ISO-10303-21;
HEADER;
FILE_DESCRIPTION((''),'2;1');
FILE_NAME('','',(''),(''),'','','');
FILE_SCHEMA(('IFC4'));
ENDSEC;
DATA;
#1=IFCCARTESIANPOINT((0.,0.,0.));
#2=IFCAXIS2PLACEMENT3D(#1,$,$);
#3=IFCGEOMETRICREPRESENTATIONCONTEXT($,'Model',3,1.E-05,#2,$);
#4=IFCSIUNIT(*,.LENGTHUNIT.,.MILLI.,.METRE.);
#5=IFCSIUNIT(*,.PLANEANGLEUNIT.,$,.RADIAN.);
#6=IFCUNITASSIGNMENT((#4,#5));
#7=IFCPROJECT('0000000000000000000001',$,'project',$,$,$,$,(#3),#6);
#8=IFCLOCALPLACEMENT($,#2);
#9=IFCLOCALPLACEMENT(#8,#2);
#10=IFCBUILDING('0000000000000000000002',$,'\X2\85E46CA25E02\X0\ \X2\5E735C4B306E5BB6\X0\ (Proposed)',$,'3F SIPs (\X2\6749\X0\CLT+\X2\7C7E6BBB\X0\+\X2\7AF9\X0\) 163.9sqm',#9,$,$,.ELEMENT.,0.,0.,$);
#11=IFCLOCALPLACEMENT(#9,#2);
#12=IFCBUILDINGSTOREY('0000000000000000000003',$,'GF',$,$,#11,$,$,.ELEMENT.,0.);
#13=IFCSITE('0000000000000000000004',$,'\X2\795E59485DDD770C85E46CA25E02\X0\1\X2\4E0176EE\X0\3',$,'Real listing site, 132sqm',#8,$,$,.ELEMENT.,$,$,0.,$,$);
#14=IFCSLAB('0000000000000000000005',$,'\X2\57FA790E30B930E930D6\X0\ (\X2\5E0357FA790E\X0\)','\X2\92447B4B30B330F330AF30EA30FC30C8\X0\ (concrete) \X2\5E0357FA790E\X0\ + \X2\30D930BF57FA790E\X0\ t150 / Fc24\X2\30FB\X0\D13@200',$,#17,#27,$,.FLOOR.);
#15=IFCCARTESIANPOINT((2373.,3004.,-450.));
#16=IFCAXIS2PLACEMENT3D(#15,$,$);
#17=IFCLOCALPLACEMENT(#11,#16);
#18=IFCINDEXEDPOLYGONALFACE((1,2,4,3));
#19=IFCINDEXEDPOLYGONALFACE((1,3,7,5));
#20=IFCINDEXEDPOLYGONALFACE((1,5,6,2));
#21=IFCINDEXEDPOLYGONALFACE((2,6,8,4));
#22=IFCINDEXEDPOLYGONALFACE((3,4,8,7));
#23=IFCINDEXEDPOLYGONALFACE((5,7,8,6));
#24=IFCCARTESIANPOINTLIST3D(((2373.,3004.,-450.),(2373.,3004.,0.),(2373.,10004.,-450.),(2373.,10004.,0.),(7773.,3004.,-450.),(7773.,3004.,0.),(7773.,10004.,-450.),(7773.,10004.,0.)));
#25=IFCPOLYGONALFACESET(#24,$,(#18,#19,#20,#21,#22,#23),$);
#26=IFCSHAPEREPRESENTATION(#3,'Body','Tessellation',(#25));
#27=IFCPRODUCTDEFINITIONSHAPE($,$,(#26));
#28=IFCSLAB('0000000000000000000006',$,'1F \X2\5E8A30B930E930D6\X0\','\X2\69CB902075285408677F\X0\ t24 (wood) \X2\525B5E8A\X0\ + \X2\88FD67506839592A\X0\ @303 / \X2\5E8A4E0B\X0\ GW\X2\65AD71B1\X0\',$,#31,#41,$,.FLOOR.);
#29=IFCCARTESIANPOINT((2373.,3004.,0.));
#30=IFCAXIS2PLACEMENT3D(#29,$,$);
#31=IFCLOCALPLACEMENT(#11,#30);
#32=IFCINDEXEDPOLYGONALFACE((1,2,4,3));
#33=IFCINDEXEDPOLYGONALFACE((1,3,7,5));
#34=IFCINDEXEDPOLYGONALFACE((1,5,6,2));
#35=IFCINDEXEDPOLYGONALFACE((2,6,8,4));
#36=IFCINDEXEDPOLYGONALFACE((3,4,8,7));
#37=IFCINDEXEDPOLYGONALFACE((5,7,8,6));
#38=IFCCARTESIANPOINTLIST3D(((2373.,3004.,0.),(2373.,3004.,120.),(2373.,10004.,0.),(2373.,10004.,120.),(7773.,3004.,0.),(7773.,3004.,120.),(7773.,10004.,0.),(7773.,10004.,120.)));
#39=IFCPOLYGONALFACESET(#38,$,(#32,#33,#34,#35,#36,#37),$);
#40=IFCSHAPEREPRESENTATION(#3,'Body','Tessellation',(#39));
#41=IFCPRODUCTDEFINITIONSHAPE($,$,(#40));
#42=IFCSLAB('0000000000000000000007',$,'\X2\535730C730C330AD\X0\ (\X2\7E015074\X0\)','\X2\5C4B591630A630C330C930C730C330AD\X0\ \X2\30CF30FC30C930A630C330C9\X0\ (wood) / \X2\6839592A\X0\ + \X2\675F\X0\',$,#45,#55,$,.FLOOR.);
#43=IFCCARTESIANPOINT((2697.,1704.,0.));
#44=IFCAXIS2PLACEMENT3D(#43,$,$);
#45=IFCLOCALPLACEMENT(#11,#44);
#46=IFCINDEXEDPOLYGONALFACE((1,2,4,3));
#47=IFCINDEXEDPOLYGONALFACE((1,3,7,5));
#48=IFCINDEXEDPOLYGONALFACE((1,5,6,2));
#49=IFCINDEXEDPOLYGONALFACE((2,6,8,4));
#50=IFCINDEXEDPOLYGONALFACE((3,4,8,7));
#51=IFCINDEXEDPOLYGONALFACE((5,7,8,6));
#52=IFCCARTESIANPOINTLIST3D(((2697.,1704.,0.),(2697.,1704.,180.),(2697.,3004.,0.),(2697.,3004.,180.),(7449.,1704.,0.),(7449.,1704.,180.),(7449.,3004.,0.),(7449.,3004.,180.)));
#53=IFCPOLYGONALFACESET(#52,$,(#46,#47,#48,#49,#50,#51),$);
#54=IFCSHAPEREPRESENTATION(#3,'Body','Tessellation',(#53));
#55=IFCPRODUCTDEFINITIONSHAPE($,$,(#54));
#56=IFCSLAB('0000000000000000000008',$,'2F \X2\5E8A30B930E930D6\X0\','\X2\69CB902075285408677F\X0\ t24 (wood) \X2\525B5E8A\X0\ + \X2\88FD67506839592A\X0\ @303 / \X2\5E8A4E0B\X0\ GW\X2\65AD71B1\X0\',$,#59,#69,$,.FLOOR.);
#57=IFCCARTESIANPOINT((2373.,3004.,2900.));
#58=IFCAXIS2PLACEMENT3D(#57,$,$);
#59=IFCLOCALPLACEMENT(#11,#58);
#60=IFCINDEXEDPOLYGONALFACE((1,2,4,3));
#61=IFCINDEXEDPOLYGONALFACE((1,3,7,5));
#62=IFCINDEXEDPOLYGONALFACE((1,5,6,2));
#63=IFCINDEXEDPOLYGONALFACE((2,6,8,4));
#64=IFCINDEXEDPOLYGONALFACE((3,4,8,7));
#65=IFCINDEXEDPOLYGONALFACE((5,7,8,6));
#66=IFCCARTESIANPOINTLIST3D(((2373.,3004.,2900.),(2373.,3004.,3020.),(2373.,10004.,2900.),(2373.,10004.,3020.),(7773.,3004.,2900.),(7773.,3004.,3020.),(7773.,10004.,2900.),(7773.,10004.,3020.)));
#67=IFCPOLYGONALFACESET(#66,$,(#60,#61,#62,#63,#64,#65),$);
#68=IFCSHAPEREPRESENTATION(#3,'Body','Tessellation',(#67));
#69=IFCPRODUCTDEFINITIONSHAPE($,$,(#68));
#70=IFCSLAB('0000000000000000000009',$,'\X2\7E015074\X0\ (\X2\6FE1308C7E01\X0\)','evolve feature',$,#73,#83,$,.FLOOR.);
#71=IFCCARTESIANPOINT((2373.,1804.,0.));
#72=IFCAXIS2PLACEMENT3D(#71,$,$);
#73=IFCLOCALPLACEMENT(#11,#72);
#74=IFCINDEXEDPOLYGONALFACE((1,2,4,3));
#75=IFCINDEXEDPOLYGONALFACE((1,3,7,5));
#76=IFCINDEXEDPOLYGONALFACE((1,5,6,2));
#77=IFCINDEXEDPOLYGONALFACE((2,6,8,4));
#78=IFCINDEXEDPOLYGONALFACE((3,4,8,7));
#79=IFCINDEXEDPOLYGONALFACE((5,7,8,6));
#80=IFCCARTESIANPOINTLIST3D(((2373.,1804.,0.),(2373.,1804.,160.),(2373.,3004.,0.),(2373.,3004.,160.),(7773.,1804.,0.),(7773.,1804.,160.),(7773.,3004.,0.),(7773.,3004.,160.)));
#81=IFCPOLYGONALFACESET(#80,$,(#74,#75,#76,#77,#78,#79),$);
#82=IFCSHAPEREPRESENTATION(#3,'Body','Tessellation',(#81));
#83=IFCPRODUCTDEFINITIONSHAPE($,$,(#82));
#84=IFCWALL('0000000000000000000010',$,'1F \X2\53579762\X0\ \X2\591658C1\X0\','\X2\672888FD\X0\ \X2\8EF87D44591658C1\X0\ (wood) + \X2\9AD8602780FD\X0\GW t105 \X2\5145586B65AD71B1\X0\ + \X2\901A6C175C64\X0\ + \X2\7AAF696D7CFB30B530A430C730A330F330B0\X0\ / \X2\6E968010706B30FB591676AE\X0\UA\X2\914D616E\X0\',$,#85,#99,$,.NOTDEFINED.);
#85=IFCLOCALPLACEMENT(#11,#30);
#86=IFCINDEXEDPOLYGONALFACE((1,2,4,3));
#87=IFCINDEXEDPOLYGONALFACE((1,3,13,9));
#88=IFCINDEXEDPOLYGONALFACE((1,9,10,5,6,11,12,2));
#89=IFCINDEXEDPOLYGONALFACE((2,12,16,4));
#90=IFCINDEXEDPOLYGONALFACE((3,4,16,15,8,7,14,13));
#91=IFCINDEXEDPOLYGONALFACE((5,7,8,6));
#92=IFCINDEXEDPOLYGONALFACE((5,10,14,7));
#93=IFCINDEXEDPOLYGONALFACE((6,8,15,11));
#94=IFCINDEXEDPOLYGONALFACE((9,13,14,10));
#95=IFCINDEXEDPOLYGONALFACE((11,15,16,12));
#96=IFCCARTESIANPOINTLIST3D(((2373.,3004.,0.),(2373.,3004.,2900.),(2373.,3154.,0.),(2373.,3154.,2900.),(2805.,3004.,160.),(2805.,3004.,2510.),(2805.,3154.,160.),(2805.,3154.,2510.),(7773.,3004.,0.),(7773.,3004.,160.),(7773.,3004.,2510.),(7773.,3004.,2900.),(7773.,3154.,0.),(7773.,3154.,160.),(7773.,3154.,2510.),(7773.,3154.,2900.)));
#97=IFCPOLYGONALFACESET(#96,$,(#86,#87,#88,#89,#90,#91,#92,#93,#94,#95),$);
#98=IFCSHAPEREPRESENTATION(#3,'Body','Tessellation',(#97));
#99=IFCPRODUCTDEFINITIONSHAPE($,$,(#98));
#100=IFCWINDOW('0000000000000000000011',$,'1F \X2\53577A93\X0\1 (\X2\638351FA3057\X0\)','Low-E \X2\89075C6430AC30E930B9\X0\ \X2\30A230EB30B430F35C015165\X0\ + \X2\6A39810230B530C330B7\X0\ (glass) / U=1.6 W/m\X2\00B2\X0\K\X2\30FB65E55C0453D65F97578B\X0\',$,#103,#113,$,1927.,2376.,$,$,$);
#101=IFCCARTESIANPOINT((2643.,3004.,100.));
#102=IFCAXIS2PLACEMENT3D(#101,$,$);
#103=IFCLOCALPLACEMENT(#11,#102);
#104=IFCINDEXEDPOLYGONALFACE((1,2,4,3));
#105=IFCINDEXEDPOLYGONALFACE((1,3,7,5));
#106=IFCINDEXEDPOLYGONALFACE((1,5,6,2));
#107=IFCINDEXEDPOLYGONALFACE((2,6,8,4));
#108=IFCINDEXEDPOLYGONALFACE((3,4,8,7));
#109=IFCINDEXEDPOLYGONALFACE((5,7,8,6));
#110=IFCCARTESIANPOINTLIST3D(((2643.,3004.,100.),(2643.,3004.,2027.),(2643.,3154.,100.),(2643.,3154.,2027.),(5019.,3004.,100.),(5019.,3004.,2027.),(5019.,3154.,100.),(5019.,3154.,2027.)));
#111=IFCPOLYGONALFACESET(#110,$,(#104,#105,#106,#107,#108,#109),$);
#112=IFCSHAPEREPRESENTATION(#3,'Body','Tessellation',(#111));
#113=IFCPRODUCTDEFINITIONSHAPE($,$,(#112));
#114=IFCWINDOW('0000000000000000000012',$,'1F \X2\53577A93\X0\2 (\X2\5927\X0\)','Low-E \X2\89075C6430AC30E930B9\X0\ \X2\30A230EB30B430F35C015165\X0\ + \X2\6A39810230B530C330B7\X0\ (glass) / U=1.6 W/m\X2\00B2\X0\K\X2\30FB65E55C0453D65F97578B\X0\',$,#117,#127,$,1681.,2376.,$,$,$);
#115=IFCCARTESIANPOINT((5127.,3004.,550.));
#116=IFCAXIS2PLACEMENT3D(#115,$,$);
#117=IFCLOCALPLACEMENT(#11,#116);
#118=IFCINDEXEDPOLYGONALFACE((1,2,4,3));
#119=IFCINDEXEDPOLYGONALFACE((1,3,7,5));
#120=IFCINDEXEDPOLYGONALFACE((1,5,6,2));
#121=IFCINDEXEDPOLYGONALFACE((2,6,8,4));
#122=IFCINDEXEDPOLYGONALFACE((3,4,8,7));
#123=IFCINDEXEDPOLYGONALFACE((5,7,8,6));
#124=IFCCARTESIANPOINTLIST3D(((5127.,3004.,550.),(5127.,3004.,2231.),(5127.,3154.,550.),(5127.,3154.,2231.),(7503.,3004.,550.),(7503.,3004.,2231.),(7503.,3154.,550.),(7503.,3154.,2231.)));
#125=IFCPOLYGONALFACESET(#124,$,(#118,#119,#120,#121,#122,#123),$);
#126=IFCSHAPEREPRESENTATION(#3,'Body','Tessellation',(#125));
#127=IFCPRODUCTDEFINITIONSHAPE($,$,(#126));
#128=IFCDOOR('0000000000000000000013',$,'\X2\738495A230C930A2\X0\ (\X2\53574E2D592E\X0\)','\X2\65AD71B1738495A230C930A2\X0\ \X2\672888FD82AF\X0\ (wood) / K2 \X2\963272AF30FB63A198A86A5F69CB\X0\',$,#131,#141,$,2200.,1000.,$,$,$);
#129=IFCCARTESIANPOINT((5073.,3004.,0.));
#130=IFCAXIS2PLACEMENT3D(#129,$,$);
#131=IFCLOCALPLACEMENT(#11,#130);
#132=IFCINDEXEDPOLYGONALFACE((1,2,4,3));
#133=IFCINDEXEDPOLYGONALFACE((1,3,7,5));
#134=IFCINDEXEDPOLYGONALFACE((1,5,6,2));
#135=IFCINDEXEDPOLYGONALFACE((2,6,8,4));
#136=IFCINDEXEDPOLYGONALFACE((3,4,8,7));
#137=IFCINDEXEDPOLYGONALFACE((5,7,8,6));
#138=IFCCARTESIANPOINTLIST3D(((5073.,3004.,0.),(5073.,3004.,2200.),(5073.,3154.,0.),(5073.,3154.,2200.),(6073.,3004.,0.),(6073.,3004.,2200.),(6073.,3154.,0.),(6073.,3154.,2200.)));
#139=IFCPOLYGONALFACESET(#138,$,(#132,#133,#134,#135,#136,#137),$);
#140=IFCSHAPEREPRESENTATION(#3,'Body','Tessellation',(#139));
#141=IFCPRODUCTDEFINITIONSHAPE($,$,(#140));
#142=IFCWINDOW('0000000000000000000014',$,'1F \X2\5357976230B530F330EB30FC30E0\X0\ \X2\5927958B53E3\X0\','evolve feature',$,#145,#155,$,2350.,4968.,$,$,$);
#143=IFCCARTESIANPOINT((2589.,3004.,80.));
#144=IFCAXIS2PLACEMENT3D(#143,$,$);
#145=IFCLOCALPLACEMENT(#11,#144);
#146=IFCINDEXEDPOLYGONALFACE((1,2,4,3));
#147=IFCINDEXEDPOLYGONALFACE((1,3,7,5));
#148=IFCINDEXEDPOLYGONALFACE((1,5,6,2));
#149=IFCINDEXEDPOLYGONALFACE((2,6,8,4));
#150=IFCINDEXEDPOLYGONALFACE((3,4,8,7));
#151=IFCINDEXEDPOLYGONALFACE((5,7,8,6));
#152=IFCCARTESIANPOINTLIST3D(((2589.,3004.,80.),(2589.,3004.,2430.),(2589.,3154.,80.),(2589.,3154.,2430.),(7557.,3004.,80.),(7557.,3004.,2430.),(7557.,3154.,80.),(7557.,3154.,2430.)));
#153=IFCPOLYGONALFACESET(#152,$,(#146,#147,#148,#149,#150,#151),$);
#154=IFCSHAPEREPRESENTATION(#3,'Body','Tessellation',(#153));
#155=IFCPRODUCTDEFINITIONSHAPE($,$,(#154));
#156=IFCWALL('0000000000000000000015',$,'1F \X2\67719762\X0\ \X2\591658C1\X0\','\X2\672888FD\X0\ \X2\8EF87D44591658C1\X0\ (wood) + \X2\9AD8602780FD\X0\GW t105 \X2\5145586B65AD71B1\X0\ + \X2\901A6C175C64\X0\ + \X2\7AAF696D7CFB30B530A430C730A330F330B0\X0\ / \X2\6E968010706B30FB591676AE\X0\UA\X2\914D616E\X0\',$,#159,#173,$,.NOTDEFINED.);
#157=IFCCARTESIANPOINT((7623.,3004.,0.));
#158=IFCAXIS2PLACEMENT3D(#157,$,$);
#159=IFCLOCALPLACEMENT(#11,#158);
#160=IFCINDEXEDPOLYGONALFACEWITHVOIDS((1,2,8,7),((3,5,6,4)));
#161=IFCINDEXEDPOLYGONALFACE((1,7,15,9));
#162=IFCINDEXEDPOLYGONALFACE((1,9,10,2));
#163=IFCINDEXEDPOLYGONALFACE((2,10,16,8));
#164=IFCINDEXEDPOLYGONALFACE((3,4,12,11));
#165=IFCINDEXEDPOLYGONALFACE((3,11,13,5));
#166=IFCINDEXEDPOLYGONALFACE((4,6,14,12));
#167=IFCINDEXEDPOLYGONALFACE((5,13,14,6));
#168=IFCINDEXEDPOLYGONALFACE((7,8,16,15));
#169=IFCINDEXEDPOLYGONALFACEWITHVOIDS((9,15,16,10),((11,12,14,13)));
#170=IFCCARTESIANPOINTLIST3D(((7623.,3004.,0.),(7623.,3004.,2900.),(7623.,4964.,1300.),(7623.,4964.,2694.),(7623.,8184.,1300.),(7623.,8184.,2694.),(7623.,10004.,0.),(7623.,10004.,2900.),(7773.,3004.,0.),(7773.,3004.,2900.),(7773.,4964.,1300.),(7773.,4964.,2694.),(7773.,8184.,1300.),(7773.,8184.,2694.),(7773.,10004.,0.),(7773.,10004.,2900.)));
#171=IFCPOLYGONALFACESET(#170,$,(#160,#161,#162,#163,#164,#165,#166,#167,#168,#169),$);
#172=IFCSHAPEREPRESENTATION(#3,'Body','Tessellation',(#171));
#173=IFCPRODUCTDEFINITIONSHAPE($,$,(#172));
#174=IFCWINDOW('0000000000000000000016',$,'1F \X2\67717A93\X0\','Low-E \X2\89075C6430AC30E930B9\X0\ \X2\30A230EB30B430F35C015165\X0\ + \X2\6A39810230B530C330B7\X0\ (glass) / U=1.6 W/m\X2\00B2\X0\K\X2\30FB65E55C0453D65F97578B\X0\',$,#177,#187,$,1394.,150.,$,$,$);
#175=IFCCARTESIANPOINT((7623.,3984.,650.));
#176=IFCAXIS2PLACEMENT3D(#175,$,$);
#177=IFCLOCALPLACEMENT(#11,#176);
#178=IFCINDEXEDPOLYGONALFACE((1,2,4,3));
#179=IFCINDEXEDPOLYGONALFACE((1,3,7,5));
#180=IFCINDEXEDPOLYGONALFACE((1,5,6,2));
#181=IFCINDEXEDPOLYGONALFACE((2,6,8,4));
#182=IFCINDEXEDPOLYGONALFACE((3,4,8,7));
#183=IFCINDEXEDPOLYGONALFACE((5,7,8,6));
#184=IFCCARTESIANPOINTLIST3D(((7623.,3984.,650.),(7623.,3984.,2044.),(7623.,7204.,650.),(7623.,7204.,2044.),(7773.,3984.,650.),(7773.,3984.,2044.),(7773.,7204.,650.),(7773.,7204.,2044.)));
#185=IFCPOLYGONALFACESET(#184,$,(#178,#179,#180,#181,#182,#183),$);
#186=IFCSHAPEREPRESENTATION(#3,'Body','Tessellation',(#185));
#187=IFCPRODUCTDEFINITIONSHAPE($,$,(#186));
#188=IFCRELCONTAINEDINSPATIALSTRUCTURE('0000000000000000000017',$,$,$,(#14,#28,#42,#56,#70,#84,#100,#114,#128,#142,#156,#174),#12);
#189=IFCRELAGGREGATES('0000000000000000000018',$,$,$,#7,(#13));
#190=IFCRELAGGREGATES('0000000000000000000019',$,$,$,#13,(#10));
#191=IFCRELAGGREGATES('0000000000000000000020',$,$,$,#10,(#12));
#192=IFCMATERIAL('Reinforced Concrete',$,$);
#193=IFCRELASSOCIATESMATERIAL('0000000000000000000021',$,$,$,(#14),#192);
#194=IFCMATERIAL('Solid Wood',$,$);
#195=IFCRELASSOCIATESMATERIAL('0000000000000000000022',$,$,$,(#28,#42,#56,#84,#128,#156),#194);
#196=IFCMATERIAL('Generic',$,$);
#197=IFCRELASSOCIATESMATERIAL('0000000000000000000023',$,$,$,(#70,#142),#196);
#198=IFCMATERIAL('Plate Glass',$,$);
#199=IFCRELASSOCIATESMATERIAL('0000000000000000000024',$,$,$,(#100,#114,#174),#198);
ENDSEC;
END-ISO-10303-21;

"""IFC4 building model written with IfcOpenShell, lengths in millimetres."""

from ifc_helpers import new_model, si_unit, frame, frame_2d, origin, place, context, project, spatial, rectangle, extrude, material, element, fill, save


model = new_model("IFC4")

# Units and contexts
model_context = context("Model", 3, precision=1e-05, world=origin())
ifc_project = project(units=[si_unit("LENGTHUNIT", "METRE", prefix="MILLI"), si_unit("PLANEANGLEUNIT", "RADIAN")], contexts=[model_context])

# Site, building, storey
site_placement = place(None, origin())
site = spatial("IfcSite", under=ifc_project, at=site_placement, Name="神奈川県藤沢市1丁目3", ObjectType="Real listing site, 132sqm", CompositionType="ELEMENT", RefElevation=0.0)
building_placement = place(site_placement, origin())
building = spatial("IfcBuilding", under=site, at=building_placement, Name="藤沢市 平屋の家 (Proposed)", ObjectType="3F SIPs (杉CLT+籾殻+竹) 163.9sqm", CompositionType="ELEMENT", ElevationOfRefHeight=0.0, ElevationOfTerrain=0.0)
storey_placement = place(building_placement, origin())
storey = spatial("IfcBuildingStorey", under=building, at=storey_placement, Name="GF", CompositionType="ELEMENT", Elevation=0.0)

# Slabs
ifc_material_1 = material(Name="Reinforced Concrete")
slab_1_placement = place(storey_placement, frame((2373.0, 3004.0, -450.0)))
element("IfcSlab", 1, at=slab_1_placement, inside=storey, material=ifc_material_1, Name="基礎スラブ (布基礎)", Description="鉄筋コンクリート (concrete) 布基礎 + ベタ基礎 t150 / Fc24・D13@200", PredefinedType="FLOOR", context=model_context, shape_type="SweptSolid", body=[
    extrude(rectangle(XDim=5400.0, YDim=7000.0, at=frame_2d((2700.0, 3500.0))), frame((2373.0, 3004.0, -450.0)), (0.0, 0.0, 1.0), 450.0),
])
ifc_material_2 = material(Name="Solid Wood")
slab_2_placement = place(storey_placement, frame((2373.0, 3004.0, 0.0)))
element("IfcSlab", 2, at=slab_2_placement, inside=storey, material=ifc_material_2, Name="1F 床スラブ", Description="構造用合板 t24 (wood) 剛床 + 製材根太 @303 / 床下 GW断熱", PredefinedType="FLOOR", context=model_context, shape_type="SweptSolid", body=[
    extrude(rectangle(XDim=5400.0, YDim=7000.0, at=frame_2d((2700.0, 3500.0))), frame((2373.0, 3004.0, 0.0)), (0.0, 0.0, 1.0), 120.0),
])
slab_3_placement = place(storey_placement, frame((2697.0, 1704.0, 0.0)))
element("IfcSlab", 3, at=slab_3_placement, inside=storey, material=ifc_material_2, Name="南デッキ (縁側)", Description="屋外ウッドデッキ ハードウッド (wood) / 根太 + 束", PredefinedType="FLOOR", context=model_context, shape_type="SweptSolid", body=[
    extrude(rectangle(XDim=4752.0, YDim=1300.0, at=frame_2d((2376.0, 650.0))), frame((2697.0, 1704.0, 0.0)), (0.0, 0.0, 1.0), 180.0),
])
slab_4_placement = place(storey_placement, frame((2373.0, 3004.0, 2900.0)))
element("IfcSlab", 4, at=slab_4_placement, inside=storey, material=ifc_material_2, Name="2F 床スラブ", Description="構造用合板 t24 (wood) 剛床 + 製材根太 @303 / 床下 GW断熱", PredefinedType="FLOOR", context=model_context, shape_type="SweptSolid", body=[
    extrude(rectangle(XDim=5400.0, YDim=7000.0, at=frame_2d((2700.0, 3500.0))), frame((2373.0, 3004.0, 2900.0)), (0.0, 0.0, 1.0), 120.0),
])
ifc_material_3 = material(Name="Generic")
slab_5_placement = place(storey_placement, frame((2373.0, 1804.0, 0.0)))
element("IfcSlab", 5, at=slab_5_placement, inside=storey, material=ifc_material_3, Name="縁側 (濡れ縁)", Description="evolve feature", PredefinedType="FLOOR", context=model_context, shape_type="SweptSolid", body=[
    extrude(rectangle(XDim=5400.0, YDim=1200.0, at=frame_2d((2700.0, 600.0))), frame((2373.0, 1804.0, 0.0)), (0.0, 0.0, 1.0), 160.0),
])

# Wall, openings, windows, door
wall_1_placement = place(storey_placement, frame((2373.0, 3004.0, 0.0)))
wall_1 = element("IfcWall", 6, at=wall_1_placement, inside=storey, material=ifc_material_2, Name="1F 南面 外壁", Description="木製 軸組外壁 (wood) + 高性能GW t105 充填断熱 + 通気層 + 窯業系サイディング / 準耐火・外皮UA配慮", PredefinedType="NOTDEFINED", context=model_context, shape_type="SweptSolid", body=[
    extrude(rectangle(XDim=5400.0, YDim=150.0, at=frame_2d((2700.0, 75.0))), frame((2373.0, 3004.0, 0.0)), (0.0, 0.0, 1.0), 2900.0),
])
opening_1_placement = place(storey_placement, frame((2643.0, 3004.0, 100.0)))
opening_1 = element("IfcOpeningElement", 7, at=opening_1_placement, cuts=wall_1, PredefinedType="NOTDEFINED", context=model_context, shape_type="SweptSolid", body=[
    extrude(rectangle(XDim=2376.0, YDim=150.0, at=frame_2d((1188.0, 75.0))), frame((2643.0, 3004.0, 100.0)), (0.0, 0.0, 1.0), 1927.0),
])
opening_2_placement = place(storey_placement, frame((5127.0, 3004.0, 550.0)))
opening_2 = element("IfcOpeningElement", 8, at=opening_2_placement, cuts=wall_1, PredefinedType="NOTDEFINED", context=model_context, shape_type="SweptSolid", body=[
    extrude(rectangle(XDim=2376.0, YDim=150.0, at=frame_2d((1188.0, 75.0))), frame((5127.0, 3004.0, 550.0)), (0.0, 0.0, 1.0), 1681.0),
])
opening_3_placement = place(storey_placement, frame((5073.0, 3004.0, 0.0)))
opening_3 = element("IfcOpeningElement", 9, at=opening_3_placement, cuts=wall_1, PredefinedType="NOTDEFINED", context=model_context, shape_type="SweptSolid", body=[
    extrude(rectangle(XDim=1000.0, YDim=150.0, at=frame_2d((500.0, 75.0))), frame((5073.0, 3004.0, 0.0)), (0.0, 0.0, 1.0), 2200.0),
])
opening_4_placement = place(storey_placement, frame((2589.0, 3004.0, 80.0)))
opening_4 = element("IfcOpeningElement", 10, at=opening_4_placement, cuts=wall_1, PredefinedType="NOTDEFINED", context=model_context, shape_type="SweptSolid", body=[
    extrude(rectangle(XDim=4968.0, YDim=150.0, at=frame_2d((2484.0, 75.0))), frame((2589.0, 3004.0, 80.0)), (0.0, 0.0, 1.0), 2350.0),
])
ifc_material_4 = material(Name="Plate Glass")
window_1_placement = place(storey_placement, frame((2643.0, 3004.0, 100.0)))
window_1 = element("IfcWindow", 11, at=window_1_placement, inside=storey, material=ifc_material_4, Name="1F 南窓1 (掃出し)", Description="Low-E 複層ガラス アルゴン封入 + 樹脂サッシ (glass) / U=1.6 W/m²K・日射取得型", OverallHeight=1927.0, OverallWidth=2376.0, context=model_context, shape_type="SweptSolid", body=[
    extrude(rectangle(XDim=2376.0, YDim=150.0, at=frame_2d((1188.0, 75.0))), frame((2643.0, 3004.0, 100.0)), (0.0, 0.0, 1.0), 1927.0),
])
fill(opening_1, window_1)
window_2_placement = place(storey_placement, frame((5127.0, 3004.0, 550.0)))
window_2 = element("IfcWindow", 12, at=window_2_placement, inside=storey, material=ifc_material_4, Name="1F 南窓2 (大)", Description="Low-E 複層ガラス アルゴン封入 + 樹脂サッシ (glass) / U=1.6 W/m²K・日射取得型", OverallHeight=1681.0, OverallWidth=2376.0, context=model_context, shape_type="SweptSolid", body=[
    extrude(rectangle(XDim=2376.0, YDim=150.0, at=frame_2d((1188.0, 75.0))), frame((5127.0, 3004.0, 550.0)), (0.0, 0.0, 1.0), 1681.0),
])
fill(opening_2, window_2)
door_placement = place(storey_placement, frame((5073.0, 3004.0, 0.0)))
door = element("IfcDoor", 13, at=door_placement, inside=storey, material=ifc_material_2, Name="玄関ドア (南中央)", Description="断熱玄関ドア 木製芯 (wood) / K2 防犯・採風機構", OverallHeight=2200.0, OverallWidth=1000.0, context=model_context, shape_type="SweptSolid", body=[
    extrude(rectangle(XDim=1000.0, YDim=150.0, at=frame_2d((500.0, 75.0))), frame((5073.0, 3004.0, 0.0)), (0.0, 0.0, 1.0), 2200.0),
])
fill(opening_3, door)
window_3_placement = place(storey_placement, frame((2589.0, 3004.0, 80.0)))
window_3 = element("IfcWindow", 14, at=window_3_placement, inside=storey, material=ifc_material_3, Name="1F 南面サンルーム 大開口", Description="evolve feature", OverallHeight=2350.0, OverallWidth=4968.0, context=model_context, shape_type="SweptSolid", body=[
    extrude(rectangle(XDim=4968.0, YDim=150.0, at=frame_2d((2484.0, 75.0))), frame((2589.0, 3004.0, 80.0)), (0.0, 0.0, 1.0), 2350.0),
])
fill(opening_4, window_3)

# Wall, opening, window
wall_2_placement = place(storey_placement, frame((7623.0, 3004.0, 0.0)))
wall_2 = element("IfcWall", 15, at=wall_2_placement, inside=storey, material=ifc_material_2, Name="1F 東面 外壁", Description="木製 軸組外壁 (wood) + 高性能GW t105 充填断熱 + 通気層 + 窯業系サイディング / 準耐火・外皮UA配慮", PredefinedType="NOTDEFINED", context=model_context, shape_type="SweptSolid", body=[
    extrude(rectangle(XDim=150.0, YDim=7000.0, at=frame_2d((75.0, 3500.0))), frame((7623.0, 3004.0, 0.0)), (0.0, 0.0, 1.0), 2900.0),
])
opening_5_placement = place(storey_placement, frame((7623.0, 3984.0, 650.0)))
opening_5 = element("IfcOpeningElement", 16, at=opening_5_placement, cuts=wall_2, PredefinedType="NOTDEFINED", context=model_context, shape_type="SweptSolid", body=[
    extrude(rectangle(XDim=150.0, YDim=3220.0, at=frame_2d((75.0, 1610.0))), frame((7623.0, 3984.0, 650.0)), (0.0, 0.0, 1.0), 1394.0),
])
window_4_placement = place(storey_placement, frame((7623.0, 3984.0, 650.0)))
window_4 = element("IfcWindow", 17, at=window_4_placement, inside=storey, material=ifc_material_4, Name="1F 東窓", Description="Low-E 複層ガラス アルゴン封入 + 樹脂サッシ (glass) / U=1.6 W/m²K・日射取得型", OverallHeight=1394.0, OverallWidth=150.0, context=model_context, shape_type="SweptSolid", body=[
    extrude(rectangle(XDim=150.0, YDim=3220.0, at=frame_2d((75.0, 1610.0))), frame((7623.0, 3984.0, 650.0)), (0.0, 0.0, 1.0), 1394.0),
])
fill(opening_5, window_4)

save(model, "model.ifc")
